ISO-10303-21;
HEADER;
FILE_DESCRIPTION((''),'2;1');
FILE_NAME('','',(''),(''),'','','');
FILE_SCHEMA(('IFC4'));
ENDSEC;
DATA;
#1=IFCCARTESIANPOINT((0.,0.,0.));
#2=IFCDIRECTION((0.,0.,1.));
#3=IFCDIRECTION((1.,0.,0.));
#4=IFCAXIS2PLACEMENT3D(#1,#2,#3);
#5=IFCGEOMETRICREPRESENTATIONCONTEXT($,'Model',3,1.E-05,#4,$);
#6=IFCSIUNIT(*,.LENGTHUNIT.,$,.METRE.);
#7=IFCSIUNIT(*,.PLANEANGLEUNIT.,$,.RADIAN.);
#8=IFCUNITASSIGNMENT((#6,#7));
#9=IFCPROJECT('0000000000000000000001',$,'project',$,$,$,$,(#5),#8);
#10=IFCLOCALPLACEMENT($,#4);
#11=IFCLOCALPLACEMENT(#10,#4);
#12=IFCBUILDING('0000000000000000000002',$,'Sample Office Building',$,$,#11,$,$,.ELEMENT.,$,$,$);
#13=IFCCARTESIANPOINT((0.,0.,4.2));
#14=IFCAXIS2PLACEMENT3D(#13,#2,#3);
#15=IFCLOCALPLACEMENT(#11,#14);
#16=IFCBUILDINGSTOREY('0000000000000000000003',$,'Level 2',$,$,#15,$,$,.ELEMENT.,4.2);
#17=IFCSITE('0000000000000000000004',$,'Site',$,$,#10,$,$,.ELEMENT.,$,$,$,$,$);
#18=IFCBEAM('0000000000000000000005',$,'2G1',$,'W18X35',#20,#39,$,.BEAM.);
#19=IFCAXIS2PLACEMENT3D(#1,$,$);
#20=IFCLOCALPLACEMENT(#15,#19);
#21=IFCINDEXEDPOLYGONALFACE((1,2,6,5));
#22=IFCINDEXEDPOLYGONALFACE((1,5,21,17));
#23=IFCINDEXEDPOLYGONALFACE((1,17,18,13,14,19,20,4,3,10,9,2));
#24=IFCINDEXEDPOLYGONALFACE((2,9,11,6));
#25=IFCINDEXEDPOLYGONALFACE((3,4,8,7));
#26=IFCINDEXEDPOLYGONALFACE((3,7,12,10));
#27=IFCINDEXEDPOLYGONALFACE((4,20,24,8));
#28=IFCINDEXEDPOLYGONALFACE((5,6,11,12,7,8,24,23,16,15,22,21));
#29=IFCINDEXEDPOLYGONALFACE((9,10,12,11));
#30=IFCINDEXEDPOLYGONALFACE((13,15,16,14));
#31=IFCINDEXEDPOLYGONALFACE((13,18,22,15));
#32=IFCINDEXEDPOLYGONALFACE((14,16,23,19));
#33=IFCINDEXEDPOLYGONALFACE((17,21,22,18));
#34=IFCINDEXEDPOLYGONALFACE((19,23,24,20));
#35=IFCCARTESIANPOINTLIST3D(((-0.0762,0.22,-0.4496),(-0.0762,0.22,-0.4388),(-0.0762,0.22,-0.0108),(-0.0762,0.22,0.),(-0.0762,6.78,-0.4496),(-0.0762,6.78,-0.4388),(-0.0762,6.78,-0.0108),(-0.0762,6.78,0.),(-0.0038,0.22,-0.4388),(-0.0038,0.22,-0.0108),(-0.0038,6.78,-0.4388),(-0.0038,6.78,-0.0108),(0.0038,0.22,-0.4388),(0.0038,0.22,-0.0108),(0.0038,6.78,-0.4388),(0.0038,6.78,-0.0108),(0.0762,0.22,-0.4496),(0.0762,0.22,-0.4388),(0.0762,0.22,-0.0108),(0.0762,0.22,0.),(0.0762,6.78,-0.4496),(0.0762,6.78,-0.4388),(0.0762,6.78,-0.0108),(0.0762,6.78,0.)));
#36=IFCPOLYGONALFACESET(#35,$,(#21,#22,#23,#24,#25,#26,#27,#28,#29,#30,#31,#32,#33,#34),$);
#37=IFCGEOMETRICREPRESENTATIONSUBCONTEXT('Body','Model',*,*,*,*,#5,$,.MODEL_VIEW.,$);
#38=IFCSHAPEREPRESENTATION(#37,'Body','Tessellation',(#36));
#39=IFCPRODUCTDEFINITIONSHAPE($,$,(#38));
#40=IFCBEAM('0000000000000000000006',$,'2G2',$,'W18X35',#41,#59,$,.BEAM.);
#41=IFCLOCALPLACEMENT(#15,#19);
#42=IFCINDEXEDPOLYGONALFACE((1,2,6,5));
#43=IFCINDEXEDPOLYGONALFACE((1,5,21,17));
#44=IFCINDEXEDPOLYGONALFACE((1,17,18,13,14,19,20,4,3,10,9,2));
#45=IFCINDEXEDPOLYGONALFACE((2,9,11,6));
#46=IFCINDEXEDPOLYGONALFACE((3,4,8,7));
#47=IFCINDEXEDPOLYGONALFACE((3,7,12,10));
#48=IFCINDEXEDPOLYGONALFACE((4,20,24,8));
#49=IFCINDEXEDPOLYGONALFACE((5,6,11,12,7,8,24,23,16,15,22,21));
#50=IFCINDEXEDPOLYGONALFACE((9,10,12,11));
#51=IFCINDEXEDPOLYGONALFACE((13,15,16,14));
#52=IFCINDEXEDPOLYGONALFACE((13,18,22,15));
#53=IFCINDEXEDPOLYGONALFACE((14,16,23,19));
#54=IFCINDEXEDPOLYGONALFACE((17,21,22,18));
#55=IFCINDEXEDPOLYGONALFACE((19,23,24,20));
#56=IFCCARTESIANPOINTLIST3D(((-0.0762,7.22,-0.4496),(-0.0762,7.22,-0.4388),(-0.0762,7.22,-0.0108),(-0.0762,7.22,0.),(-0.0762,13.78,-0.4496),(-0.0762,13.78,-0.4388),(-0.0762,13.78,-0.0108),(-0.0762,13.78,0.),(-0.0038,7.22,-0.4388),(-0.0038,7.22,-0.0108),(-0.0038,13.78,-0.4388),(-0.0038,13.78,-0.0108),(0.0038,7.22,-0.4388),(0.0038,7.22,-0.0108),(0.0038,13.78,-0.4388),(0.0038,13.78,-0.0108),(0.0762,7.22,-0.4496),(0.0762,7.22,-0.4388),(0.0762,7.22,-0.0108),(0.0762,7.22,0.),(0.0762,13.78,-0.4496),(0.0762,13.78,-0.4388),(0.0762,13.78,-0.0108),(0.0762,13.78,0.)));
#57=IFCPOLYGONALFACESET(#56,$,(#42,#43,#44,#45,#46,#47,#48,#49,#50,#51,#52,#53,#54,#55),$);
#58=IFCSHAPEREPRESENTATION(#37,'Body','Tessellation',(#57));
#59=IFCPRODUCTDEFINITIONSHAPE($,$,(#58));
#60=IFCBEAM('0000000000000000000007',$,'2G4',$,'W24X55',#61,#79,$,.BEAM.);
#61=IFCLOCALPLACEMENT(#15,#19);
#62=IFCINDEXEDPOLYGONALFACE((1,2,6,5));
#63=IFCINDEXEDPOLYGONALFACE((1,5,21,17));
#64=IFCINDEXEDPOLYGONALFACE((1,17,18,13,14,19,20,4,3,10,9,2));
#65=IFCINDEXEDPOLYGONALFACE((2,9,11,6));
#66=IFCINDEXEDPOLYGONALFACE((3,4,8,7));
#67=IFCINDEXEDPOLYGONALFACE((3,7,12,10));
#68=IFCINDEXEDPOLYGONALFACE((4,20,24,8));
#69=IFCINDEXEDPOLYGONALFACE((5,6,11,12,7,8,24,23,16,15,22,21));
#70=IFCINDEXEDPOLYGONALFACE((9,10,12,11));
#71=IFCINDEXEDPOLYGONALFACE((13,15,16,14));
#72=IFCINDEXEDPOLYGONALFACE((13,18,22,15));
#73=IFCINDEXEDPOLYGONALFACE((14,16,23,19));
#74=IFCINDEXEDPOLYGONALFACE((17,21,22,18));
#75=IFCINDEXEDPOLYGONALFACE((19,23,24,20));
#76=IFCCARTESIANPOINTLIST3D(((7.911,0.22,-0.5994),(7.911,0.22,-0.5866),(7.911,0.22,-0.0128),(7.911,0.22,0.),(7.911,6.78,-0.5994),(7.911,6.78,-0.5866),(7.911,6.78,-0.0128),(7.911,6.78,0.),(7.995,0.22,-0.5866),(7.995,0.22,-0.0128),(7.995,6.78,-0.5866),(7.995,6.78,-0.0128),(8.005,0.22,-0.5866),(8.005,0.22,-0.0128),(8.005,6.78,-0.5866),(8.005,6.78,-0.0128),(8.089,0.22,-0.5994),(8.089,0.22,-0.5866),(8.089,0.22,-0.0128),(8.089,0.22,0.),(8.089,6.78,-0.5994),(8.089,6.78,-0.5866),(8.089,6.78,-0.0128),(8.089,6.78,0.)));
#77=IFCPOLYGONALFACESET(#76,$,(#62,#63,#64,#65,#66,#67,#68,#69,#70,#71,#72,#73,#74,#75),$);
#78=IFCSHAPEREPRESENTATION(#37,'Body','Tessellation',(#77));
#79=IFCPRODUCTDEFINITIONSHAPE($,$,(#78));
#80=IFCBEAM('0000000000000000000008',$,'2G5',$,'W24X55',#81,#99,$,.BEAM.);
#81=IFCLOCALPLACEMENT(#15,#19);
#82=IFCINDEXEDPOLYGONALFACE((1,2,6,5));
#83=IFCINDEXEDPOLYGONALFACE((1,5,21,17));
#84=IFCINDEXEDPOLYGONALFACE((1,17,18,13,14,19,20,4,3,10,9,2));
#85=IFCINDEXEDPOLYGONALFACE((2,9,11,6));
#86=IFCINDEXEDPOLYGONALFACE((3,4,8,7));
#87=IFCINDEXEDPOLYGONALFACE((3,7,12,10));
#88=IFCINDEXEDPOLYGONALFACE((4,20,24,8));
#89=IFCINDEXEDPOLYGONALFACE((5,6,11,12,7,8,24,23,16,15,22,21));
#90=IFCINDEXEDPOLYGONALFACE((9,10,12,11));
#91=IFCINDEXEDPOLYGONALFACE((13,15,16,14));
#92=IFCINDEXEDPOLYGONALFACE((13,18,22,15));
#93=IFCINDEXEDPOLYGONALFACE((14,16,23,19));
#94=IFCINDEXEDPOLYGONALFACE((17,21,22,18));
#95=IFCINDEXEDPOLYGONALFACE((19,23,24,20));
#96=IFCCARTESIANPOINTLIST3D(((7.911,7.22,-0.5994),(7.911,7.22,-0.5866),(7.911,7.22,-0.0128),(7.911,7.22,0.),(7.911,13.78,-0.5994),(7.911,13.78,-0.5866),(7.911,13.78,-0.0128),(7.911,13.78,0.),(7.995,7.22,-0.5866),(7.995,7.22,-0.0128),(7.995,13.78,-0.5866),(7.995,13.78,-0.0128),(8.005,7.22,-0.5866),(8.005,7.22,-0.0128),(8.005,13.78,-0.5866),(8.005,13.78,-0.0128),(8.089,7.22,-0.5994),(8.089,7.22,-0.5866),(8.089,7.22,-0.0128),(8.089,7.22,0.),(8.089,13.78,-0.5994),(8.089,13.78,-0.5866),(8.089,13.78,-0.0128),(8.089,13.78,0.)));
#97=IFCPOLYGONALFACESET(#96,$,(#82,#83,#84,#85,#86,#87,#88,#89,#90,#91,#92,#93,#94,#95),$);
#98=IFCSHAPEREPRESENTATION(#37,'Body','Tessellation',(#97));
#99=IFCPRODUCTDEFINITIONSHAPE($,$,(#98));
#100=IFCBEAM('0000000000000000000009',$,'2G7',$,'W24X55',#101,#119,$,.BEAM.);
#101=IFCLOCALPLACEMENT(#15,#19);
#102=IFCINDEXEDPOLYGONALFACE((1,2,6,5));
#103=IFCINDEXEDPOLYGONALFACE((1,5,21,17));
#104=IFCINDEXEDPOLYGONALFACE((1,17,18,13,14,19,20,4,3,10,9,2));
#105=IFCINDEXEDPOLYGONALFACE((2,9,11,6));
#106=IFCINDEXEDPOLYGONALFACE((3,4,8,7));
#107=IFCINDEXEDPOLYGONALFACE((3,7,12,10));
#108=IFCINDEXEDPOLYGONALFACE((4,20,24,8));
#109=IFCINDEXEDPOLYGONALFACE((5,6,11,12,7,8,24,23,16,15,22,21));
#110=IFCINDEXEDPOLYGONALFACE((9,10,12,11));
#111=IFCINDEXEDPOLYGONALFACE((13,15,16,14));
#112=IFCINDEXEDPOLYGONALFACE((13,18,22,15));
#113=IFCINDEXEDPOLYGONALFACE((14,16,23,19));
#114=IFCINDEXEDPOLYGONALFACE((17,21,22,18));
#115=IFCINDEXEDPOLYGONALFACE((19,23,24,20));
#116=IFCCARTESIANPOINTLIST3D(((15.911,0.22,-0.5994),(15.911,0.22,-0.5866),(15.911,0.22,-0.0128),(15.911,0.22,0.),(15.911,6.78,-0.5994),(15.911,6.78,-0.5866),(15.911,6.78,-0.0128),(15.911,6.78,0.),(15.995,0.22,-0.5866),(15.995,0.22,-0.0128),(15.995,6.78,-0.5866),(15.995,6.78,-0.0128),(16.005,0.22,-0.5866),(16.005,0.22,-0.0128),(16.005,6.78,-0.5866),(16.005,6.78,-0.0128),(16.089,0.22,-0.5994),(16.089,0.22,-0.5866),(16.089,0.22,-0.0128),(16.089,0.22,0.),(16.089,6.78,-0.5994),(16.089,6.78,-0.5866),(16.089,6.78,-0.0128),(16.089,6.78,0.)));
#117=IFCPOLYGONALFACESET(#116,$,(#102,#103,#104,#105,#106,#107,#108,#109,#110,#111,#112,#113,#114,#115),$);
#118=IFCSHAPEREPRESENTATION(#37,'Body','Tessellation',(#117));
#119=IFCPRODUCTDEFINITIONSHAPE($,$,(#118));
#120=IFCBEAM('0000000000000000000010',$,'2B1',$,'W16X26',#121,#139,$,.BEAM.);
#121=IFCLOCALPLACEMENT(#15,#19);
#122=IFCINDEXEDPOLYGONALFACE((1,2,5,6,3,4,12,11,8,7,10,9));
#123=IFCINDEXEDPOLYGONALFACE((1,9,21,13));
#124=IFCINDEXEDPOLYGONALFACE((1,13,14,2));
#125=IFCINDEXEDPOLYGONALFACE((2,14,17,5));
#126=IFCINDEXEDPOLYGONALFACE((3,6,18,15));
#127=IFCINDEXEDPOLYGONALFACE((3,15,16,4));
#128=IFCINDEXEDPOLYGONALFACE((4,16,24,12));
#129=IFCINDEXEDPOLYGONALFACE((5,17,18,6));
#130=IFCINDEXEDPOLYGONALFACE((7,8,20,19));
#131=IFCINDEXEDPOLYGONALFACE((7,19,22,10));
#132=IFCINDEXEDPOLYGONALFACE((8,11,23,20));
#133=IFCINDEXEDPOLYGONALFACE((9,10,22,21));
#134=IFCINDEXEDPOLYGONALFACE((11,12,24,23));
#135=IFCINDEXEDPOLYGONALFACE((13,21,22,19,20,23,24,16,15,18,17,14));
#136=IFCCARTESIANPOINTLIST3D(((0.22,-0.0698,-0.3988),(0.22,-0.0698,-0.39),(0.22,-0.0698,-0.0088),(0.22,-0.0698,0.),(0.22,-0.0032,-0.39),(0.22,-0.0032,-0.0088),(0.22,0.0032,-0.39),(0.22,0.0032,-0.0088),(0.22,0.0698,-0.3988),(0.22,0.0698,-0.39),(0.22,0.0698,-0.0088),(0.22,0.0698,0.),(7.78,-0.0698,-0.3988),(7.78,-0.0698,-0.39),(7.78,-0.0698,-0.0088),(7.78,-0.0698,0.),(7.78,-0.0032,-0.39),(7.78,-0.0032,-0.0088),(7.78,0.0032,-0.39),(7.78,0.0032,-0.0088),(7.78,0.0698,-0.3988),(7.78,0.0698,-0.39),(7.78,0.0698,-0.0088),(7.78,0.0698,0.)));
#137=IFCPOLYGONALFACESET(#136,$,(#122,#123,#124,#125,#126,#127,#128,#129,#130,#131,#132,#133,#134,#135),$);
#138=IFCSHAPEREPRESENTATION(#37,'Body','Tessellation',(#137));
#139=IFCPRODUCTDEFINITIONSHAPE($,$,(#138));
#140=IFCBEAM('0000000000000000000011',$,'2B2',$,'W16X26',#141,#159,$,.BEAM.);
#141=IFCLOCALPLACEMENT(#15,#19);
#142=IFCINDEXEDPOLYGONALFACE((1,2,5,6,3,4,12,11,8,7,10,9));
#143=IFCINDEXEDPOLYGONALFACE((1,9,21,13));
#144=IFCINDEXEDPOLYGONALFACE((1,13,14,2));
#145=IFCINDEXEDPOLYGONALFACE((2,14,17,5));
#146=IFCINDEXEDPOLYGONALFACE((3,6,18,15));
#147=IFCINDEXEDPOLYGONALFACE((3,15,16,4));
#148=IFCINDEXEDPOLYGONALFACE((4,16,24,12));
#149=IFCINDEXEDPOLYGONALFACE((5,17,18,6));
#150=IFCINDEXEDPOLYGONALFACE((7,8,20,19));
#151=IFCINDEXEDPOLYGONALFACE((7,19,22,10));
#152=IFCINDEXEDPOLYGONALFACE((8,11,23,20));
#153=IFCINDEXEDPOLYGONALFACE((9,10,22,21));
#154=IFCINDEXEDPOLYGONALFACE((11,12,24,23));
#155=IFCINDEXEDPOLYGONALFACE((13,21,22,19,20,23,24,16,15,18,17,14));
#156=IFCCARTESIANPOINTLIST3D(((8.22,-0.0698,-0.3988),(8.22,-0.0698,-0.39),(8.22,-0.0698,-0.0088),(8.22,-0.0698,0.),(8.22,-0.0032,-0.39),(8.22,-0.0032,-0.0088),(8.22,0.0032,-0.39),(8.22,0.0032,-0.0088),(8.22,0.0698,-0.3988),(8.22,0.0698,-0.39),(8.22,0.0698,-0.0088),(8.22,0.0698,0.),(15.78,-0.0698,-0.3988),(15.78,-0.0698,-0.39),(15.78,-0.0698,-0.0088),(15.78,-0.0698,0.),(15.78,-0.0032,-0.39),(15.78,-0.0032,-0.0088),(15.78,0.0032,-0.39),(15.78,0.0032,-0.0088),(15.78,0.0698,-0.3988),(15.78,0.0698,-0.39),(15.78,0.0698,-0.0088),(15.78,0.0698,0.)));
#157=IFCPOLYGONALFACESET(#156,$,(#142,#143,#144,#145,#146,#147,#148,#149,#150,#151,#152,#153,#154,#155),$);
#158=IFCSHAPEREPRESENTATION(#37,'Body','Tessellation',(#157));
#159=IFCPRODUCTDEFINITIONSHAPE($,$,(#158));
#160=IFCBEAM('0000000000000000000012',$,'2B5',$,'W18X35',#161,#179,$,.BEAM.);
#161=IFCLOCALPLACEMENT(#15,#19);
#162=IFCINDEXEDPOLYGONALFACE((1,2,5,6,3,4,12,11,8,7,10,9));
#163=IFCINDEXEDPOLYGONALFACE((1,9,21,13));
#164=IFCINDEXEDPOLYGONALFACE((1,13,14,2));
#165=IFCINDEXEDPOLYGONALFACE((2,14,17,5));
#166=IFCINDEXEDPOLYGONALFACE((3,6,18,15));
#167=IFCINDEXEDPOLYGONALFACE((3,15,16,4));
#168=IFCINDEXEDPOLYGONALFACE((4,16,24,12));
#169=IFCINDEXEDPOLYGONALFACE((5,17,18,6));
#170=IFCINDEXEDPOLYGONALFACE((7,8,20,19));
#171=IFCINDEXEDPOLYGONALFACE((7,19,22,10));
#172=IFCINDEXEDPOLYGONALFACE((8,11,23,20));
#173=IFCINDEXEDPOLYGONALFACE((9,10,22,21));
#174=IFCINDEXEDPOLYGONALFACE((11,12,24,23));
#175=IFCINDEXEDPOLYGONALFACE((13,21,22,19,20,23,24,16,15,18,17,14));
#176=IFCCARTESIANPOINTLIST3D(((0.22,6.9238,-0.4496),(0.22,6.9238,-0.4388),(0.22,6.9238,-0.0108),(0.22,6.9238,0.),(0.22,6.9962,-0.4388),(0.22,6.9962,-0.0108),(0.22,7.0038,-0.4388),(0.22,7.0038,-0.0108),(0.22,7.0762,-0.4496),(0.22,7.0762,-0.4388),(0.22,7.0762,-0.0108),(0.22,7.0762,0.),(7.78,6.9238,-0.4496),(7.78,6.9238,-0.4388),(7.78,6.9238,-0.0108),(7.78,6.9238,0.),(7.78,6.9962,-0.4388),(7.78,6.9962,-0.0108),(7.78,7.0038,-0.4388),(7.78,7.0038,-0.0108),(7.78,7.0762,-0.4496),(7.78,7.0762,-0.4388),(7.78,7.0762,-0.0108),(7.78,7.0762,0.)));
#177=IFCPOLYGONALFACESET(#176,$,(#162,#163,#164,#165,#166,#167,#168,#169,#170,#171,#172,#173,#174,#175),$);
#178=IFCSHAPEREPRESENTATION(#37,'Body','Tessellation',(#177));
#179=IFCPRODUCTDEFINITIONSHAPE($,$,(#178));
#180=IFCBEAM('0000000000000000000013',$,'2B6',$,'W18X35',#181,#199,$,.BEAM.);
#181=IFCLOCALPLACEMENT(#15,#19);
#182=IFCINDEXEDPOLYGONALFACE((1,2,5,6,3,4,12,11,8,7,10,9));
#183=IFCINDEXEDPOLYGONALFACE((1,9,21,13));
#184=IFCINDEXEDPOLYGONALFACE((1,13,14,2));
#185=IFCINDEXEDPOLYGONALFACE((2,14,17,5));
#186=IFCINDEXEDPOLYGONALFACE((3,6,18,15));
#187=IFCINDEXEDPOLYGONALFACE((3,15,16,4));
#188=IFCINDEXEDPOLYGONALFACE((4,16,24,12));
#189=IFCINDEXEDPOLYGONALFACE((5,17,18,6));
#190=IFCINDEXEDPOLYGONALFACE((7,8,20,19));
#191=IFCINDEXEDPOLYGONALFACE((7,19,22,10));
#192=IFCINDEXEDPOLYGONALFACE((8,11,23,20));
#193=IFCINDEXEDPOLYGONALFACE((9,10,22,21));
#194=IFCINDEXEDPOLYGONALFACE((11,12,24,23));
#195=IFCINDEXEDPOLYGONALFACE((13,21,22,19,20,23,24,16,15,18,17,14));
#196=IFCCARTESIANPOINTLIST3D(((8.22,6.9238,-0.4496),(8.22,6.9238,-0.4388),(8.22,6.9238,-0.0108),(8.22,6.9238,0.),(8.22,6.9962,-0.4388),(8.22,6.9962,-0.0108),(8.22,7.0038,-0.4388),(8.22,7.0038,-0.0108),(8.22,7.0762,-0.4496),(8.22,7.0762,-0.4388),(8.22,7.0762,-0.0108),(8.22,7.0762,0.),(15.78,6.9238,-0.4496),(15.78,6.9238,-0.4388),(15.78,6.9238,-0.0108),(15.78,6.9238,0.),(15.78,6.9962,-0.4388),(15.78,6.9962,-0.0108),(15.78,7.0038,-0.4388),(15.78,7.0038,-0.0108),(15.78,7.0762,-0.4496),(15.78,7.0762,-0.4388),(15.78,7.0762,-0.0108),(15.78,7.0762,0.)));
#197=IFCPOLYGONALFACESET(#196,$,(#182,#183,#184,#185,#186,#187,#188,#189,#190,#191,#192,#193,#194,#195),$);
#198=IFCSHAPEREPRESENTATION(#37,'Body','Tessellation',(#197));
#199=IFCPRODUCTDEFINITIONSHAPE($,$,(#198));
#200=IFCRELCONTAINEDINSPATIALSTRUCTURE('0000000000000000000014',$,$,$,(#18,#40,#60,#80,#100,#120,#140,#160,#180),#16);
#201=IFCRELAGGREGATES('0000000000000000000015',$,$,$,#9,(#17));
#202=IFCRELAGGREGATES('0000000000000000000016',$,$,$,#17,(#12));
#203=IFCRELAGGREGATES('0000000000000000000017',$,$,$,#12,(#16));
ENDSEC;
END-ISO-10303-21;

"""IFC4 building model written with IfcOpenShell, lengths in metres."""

from ifc_helpers import new_model, si_unit, frame, origin_with_axes, place, context, subcontext, project, spatial, i_section, extrude, element, save


model = new_model("IFC4")

# Units and contexts
model_context = context("Model", 3, precision=1e-05, world=origin_with_axes())
body_context = subcontext(model_context, "Body", "Model", "MODEL_VIEW")
ifc_project = project(units=[si_unit("LENGTHUNIT", "METRE"), si_unit("PLANEANGLEUNIT", "RADIAN")], contexts=[model_context])

# Site, building, storey
site_placement = place(None, origin_with_axes())
site = spatial("IfcSite", under=ifc_project, at=site_placement, Name="Site", CompositionType="ELEMENT")
building_placement = place(site_placement, origin_with_axes())
building = spatial("IfcBuilding", under=site, at=building_placement, Name="Sample Office Building", CompositionType="ELEMENT")
storey_placement = place(building_placement, frame((0.0, 0.0, 4.2), z_axis=(0.0, 0.0, 1.0), x_axis=(1.0, 0.0, 0.0)))
storey = spatial("IfcBuildingStorey", under=building, at=storey_placement, Name="Level 2", CompositionType="ELEMENT", Elevation=4.2)

# Beams
beam_1_placement = place(None, frame((0.0, 0.22, 3.9752), z_axis=(0.0, 1.0, 0.0), x_axis=(-1.0, 0.0, 0.0)))
element("IfcBeam", 1, at=beam_1_placement, inside=storey, Name="2G1", ObjectType="W18X35", PredefinedType="BEAM", context=body_context, shape_type="SweptSolid", body=[
    extrude(i_section(OverallWidth=0.1524, OverallDepth=0.4496, WebThickness=0.0076, FlangeThickness=0.0108), None, (0.0, 0.0, 1.0), 6.56),
])
beam_2_placement = place(None, frame((0.0, 7.22, 3.9752), z_axis=(0.0, 1.0, 0.0), x_axis=(-1.0, 0.0, 0.0)))
element("IfcBeam", 2, at=beam_2_placement, inside=storey, Name="2G2", ObjectType="W18X35", PredefinedType="BEAM", context=body_context, shape_type="SweptSolid", body=[
    extrude(i_section(OverallWidth=0.1524, OverallDepth=0.4496, WebThickness=0.0076, FlangeThickness=0.0108), None, (0.0, 0.0, 1.0), 6.56),
])
beam_3_placement = place(None, frame((8.0, 0.22, 3.9003), z_axis=(0.0, 1.0, 0.0), x_axis=(-1.0, 0.0, 0.0)))
element("IfcBeam", 3, at=beam_3_placement, inside=storey, Name="2G4", ObjectType="W24X55", PredefinedType="BEAM", context=body_context, shape_type="SweptSolid", body=[
    extrude(i_section(OverallWidth=0.1781, OverallDepth=0.5994, WebThickness=0.01, FlangeThickness=0.0128), None, (0.0, 0.0, 1.0), 6.56),
])
beam_4_placement = place(None, frame((8.0, 7.22, 3.9003), z_axis=(0.0, 1.0, 0.0), x_axis=(-1.0, 0.0, 0.0)))
element("IfcBeam", 4, at=beam_4_placement, inside=storey, Name="2G5", ObjectType="W24X55", PredefinedType="BEAM", context=body_context, shape_type="SweptSolid", body=[
    extrude(i_section(OverallWidth=0.1781, OverallDepth=0.5994, WebThickness=0.01, FlangeThickness=0.0128), None, (0.0, 0.0, 1.0), 6.56),
])
beam_5_placement = place(None, frame((16.0, 0.22, 3.9003), z_axis=(0.0, 1.0, 0.0), x_axis=(-1.0, 0.0, 0.0)))
element("IfcBeam", 5, at=beam_5_placement, inside=storey, Name="2G7", ObjectType="W24X55", PredefinedType="BEAM", context=body_context, shape_type="SweptSolid", body=[
    extrude(i_section(OverallWidth=0.1781, OverallDepth=0.5994, WebThickness=0.01, FlangeThickness=0.0128), None, (0.0, 0.0, 1.0), 6.56),
])
beam_6_placement = place(None, frame((0.22, 0.0, 4.0006), z_axis=(1.0, 0.0, 0.0), x_axis=(0.0, 1.0, 0.0)))
element("IfcBeam", 6, at=beam_6_placement, inside=storey, Name="2B1", ObjectType="W16X26", PredefinedType="BEAM", context=body_context, shape_type="SweptSolid", body=[
    extrude(i_section(OverallWidth=0.1397, OverallDepth=0.3988, WebThickness=0.0063, FlangeThickness=0.0088), None, (0.0, 0.0, 1.0), 7.56),
])
beam_7_placement = place(None, frame((8.22, 0.0, 4.0006), z_axis=(1.0, 0.0, 0.0), x_axis=(0.0, 1.0, 0.0)))
element("IfcBeam", 7, at=beam_7_placement, inside=storey, Name="2B2", ObjectType="W16X26", PredefinedType="BEAM", context=body_context, shape_type="SweptSolid", body=[
    extrude(i_section(OverallWidth=0.1397, OverallDepth=0.3988, WebThickness=0.0063, FlangeThickness=0.0088), None, (0.0, 0.0, 1.0), 7.56),
])
beam_8_placement = place(None, frame((0.22, 7.0, 3.9752), z_axis=(1.0, 0.0, 0.0), x_axis=(0.0, 1.0, 0.0)))
element("IfcBeam", 8, at=beam_8_placement, inside=storey, Name="2B5", ObjectType="W18X35", PredefinedType="BEAM", context=body_context, shape_type="SweptSolid", body=[
    extrude(i_section(OverallWidth=0.1524, OverallDepth=0.4496, WebThickness=0.0076, FlangeThickness=0.0108), None, (0.0, 0.0, 1.0), 7.56),
])
beam_9_placement = place(None, frame((8.22, 7.0, 3.9752), z_axis=(1.0, 0.0, 0.0), x_axis=(0.0, 1.0, 0.0)))
element("IfcBeam", 9, at=beam_9_placement, inside=storey, Name="2B6", ObjectType="W18X35", PredefinedType="BEAM", context=body_context, shape_type="SweptSolid", body=[
    extrude(i_section(OverallWidth=0.1524, OverallDepth=0.4496, WebThickness=0.0076, FlangeThickness=0.0108), None, (0.0, 0.0, 1.0), 7.56),
])

save(model, "model.ifc")
